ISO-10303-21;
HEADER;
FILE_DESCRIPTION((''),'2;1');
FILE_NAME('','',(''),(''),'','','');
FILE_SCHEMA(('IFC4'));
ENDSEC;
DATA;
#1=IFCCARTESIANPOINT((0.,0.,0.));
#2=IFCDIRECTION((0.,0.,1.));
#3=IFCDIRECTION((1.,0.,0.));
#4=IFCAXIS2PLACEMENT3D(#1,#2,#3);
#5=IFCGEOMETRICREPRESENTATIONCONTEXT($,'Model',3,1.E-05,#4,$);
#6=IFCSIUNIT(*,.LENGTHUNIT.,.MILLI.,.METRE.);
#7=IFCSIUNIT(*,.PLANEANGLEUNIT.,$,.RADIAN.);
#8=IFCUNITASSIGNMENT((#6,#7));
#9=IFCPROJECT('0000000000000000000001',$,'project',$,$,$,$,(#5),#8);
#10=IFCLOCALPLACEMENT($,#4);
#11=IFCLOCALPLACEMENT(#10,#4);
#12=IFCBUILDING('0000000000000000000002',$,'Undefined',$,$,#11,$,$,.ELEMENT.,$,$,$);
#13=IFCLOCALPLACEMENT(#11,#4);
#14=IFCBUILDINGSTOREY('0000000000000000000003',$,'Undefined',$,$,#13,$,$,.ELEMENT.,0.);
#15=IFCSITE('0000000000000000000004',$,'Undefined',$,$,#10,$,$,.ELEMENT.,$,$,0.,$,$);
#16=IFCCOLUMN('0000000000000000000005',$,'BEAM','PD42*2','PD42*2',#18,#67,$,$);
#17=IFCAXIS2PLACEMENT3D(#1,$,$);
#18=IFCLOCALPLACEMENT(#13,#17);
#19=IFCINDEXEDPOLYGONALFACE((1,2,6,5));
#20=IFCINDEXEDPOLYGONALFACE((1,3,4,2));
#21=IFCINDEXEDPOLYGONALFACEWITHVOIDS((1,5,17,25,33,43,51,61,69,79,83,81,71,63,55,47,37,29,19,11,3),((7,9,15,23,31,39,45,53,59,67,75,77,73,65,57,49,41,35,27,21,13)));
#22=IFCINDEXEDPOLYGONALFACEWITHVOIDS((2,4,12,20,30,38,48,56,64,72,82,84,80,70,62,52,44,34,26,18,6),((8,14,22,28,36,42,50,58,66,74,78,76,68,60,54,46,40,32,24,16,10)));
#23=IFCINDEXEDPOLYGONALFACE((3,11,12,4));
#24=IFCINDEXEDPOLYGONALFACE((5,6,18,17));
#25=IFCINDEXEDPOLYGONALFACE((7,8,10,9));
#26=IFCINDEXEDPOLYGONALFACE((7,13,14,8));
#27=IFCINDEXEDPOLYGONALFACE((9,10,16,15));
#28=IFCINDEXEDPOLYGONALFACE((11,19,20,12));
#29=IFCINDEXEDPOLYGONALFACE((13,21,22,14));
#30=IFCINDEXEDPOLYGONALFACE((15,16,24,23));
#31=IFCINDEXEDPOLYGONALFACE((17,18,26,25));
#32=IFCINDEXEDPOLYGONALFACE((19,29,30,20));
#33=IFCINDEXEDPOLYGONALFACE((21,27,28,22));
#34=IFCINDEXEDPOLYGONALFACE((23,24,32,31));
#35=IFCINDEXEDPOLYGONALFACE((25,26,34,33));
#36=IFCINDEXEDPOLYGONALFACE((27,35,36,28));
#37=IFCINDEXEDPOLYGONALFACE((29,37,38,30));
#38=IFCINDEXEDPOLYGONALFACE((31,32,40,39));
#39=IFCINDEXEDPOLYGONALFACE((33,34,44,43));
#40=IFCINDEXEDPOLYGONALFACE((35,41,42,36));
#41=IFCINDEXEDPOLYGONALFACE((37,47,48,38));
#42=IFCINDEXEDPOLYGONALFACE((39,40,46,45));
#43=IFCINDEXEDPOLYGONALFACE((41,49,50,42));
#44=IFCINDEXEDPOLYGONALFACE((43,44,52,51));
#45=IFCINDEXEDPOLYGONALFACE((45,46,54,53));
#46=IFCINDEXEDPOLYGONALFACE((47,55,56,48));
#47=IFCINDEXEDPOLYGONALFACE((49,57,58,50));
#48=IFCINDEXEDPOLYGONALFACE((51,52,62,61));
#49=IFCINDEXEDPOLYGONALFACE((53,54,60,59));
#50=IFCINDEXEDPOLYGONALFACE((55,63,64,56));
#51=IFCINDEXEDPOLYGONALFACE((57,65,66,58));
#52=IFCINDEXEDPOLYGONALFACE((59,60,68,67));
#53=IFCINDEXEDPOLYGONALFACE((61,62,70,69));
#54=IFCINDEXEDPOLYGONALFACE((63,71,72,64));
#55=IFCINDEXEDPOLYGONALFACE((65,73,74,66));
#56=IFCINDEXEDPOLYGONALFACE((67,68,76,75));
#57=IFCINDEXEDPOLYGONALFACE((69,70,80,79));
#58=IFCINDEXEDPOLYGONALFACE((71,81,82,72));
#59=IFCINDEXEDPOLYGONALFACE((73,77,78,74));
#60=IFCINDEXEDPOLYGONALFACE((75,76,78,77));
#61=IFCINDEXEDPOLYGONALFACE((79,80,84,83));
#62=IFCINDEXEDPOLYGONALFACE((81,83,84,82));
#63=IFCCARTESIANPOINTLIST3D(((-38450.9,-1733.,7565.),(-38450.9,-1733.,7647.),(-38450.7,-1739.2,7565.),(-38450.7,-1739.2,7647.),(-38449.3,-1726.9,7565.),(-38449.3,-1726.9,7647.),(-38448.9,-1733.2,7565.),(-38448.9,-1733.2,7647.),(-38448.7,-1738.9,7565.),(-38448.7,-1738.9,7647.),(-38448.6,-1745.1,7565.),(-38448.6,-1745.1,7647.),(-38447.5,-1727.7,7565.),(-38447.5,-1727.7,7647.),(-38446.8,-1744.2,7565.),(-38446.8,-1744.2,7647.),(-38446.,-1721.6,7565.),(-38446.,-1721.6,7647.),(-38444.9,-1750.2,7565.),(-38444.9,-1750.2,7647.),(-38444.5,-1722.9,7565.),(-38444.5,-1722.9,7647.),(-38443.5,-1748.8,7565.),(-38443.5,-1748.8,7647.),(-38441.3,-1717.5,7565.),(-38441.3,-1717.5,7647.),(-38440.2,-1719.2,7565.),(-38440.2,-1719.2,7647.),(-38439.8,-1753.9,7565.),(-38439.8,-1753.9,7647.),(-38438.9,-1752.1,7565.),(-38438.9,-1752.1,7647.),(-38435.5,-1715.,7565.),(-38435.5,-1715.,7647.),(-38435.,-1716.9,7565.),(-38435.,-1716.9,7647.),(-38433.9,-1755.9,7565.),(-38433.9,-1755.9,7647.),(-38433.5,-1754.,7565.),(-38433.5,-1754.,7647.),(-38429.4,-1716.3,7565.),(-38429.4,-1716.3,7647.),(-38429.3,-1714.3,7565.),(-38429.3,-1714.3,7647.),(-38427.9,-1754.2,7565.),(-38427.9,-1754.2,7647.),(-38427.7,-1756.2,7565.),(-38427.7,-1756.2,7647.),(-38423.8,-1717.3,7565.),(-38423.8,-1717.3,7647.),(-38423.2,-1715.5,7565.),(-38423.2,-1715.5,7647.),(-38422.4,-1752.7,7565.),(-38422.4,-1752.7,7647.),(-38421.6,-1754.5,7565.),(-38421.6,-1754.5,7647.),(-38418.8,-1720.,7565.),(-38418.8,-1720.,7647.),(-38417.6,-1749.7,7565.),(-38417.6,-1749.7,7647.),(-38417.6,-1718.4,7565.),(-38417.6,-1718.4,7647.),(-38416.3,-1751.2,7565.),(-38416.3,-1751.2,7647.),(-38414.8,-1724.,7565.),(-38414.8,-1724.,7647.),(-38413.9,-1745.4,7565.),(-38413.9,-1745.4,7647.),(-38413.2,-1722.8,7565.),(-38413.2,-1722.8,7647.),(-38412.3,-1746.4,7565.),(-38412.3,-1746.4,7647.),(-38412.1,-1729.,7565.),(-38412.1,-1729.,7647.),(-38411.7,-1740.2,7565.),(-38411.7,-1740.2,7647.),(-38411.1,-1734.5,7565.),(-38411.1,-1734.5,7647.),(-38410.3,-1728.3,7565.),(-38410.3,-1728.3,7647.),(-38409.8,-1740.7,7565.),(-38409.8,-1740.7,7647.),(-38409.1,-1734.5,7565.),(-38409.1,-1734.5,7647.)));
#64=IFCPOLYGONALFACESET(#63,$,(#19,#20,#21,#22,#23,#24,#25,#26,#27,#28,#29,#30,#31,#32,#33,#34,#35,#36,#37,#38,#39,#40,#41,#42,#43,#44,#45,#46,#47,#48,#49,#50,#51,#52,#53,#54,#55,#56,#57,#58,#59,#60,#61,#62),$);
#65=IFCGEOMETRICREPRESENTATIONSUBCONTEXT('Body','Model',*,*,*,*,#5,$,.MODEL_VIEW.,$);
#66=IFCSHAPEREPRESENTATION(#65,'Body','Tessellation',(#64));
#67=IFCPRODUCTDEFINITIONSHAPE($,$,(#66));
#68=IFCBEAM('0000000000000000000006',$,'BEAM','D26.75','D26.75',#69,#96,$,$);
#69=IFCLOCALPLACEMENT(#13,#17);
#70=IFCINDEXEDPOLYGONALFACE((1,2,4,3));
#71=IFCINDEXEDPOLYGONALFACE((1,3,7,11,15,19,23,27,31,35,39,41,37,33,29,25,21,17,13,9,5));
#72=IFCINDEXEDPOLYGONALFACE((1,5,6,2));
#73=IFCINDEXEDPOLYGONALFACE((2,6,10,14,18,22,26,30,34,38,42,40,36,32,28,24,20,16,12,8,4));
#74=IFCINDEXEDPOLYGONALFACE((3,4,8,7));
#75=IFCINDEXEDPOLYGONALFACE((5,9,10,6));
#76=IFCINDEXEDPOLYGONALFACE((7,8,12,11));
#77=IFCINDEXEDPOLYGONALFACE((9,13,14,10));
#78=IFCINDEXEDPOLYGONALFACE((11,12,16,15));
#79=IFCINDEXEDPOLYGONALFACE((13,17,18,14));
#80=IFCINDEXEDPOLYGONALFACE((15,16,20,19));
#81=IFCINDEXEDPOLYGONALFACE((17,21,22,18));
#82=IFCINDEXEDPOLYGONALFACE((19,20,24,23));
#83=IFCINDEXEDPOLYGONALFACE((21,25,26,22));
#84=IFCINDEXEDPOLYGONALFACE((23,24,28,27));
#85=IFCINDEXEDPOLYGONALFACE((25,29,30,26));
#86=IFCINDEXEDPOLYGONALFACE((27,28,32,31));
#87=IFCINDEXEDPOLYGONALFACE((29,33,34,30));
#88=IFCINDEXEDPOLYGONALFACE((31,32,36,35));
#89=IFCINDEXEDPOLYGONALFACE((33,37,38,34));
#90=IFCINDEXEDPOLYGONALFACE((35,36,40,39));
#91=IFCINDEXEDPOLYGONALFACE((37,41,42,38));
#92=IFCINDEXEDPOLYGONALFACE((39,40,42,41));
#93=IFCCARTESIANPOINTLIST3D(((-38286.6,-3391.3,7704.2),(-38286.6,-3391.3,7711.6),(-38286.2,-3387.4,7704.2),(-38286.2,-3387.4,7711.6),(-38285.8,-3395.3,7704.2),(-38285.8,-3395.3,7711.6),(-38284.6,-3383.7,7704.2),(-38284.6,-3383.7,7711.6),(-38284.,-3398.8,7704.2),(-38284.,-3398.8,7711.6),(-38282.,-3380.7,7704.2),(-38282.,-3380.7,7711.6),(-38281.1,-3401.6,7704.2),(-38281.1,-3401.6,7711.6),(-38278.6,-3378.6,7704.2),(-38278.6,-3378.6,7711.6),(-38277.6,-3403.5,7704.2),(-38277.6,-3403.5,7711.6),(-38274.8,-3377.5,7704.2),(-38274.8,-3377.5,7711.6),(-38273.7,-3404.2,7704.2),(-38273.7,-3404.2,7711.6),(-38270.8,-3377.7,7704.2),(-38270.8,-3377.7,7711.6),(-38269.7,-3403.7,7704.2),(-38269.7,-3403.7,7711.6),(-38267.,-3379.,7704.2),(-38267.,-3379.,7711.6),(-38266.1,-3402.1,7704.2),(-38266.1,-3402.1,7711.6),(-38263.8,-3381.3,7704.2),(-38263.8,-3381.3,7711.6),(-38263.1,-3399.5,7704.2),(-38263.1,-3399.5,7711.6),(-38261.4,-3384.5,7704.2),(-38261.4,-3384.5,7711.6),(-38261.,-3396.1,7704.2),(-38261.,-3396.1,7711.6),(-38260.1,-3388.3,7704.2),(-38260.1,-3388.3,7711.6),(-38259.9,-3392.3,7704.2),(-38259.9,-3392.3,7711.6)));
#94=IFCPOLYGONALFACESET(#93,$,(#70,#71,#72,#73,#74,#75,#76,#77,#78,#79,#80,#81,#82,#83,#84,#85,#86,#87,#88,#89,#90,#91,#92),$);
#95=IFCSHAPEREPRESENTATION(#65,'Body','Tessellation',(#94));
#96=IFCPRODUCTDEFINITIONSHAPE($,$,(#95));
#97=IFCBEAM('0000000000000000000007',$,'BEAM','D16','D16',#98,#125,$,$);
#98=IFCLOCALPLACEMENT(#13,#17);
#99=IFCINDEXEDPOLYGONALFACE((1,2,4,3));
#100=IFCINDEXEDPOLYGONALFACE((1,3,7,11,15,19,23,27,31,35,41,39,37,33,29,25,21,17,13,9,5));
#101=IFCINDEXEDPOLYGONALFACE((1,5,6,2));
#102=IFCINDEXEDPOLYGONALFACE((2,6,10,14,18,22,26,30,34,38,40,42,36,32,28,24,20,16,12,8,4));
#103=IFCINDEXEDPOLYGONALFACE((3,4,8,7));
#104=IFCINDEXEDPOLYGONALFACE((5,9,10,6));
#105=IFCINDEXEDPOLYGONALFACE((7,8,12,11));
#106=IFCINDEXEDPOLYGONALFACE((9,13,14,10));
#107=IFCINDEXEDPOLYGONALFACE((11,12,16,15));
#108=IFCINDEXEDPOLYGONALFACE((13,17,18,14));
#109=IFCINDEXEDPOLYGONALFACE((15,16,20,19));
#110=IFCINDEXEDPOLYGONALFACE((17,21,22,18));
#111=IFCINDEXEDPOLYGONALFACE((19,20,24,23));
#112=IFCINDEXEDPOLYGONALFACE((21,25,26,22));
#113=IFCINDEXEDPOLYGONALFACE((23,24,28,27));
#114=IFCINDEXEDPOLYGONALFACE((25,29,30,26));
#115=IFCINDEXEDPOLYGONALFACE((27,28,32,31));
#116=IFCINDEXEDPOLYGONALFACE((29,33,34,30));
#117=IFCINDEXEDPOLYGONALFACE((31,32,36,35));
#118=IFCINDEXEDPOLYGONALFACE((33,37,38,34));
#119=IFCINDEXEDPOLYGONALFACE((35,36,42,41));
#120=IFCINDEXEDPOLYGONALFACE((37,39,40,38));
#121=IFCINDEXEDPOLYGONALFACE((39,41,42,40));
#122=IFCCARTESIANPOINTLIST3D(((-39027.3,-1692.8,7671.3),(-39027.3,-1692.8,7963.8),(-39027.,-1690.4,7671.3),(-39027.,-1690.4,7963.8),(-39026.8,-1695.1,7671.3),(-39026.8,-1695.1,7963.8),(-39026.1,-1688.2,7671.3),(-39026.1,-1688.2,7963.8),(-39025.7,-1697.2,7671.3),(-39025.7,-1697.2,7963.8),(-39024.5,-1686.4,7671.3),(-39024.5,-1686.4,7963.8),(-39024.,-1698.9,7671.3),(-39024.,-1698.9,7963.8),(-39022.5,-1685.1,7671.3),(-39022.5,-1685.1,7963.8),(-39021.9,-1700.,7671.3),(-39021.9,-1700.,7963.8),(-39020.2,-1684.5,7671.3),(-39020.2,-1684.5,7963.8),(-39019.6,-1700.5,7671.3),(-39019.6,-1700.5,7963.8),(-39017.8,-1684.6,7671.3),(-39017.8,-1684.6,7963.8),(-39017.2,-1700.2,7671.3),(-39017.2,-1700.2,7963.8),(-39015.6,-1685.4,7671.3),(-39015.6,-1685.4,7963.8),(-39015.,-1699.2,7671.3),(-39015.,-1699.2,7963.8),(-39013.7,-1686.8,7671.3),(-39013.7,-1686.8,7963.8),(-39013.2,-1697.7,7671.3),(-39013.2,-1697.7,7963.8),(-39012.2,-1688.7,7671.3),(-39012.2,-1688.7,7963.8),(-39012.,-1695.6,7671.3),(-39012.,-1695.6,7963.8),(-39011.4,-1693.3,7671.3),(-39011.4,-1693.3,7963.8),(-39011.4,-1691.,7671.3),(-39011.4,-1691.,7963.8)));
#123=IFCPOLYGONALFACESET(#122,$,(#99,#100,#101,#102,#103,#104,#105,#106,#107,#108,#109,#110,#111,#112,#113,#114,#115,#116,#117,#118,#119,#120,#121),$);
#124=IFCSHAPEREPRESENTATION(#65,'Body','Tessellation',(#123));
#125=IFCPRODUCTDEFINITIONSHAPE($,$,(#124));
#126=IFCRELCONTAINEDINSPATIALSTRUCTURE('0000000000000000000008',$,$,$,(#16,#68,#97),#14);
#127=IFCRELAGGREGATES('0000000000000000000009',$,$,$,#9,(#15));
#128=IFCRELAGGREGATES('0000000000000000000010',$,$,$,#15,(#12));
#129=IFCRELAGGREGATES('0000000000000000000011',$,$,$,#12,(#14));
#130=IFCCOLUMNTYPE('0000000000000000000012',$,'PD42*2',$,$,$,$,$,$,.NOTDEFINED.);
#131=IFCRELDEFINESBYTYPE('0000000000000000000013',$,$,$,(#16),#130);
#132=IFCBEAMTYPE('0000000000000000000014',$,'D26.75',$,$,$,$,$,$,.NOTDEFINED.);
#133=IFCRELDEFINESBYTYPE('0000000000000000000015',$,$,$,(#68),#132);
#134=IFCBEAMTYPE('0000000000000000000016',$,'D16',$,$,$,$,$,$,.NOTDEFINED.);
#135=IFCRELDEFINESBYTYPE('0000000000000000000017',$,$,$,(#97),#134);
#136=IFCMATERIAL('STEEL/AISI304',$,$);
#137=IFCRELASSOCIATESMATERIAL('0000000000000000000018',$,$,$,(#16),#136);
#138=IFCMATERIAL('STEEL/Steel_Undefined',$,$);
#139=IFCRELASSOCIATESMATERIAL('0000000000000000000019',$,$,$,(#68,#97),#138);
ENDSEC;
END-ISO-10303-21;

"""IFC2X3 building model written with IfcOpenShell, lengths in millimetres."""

from ifc_helpers import new_model, si_unit, frame, origin_with_axes, origin_2d_with_axis, place, context, subcontext, project, spatial, circle, hollow_circle, extrude, material, type_object, element, save


model = new_model("IFC2X3")

# Units and contexts
model_context = context("Model", 3, precision=1e-05, world=origin_with_axes())
body_context = subcontext(model_context, "Body", "Model", "MODEL_VIEW")
ifc_project = project(units=[si_unit("LENGTHUNIT", "METRE", prefix="MILLI"), si_unit("PLANEANGLEUNIT", "RADIAN")], contexts=[model_context])

# Site, building, storey
site_placement = place(None, origin_with_axes())
site = spatial("IfcSite", under=ifc_project, at=site_placement, Name="Undefined", CompositionType="ELEMENT", RefElevation=0.0)
building_placement = place(site_placement, origin_with_axes())
building = spatial("IfcBuilding", under=site, at=building_placement, Name="Undefined", CompositionType="ELEMENT")
storey_placement = place(building_placement, origin_with_axes())
storey = spatial("IfcBuildingStorey", under=building, at=storey_placement, Name="Undefined", CompositionType="ELEMENT", Elevation=0.0)

# Column
ifc_material_1 = material(Name="STEEL/AISI304")
column_type = type_object("IfcColumnType", Name="PD42*2", PredefinedType="NOTDEFINED")
column_placement = place(storey_placement, frame((-38430.1, -1735.3, 7565.0), z_axis=(0.0, 0.0, 1.0), x_axis=(1.0, 0.0, 0.0)))
element("IfcColumn", 1, at=column_placement, inside=storey, type_object=column_type, material=ifc_material_1, Name="BEAM", Description="PD42*2", ObjectType="PD42*2", context=body_context, shape_type="SweptSolid", body=[
    extrude(hollow_circle(Radius=21.0, WallThickness=2.0, at=origin_2d_with_axis()), frame((0.0, 0.0, 82.0), z_axis=(0.0, 0.0, -1.0), x_axis=(0.402197, -0.915553, 0.0)), (0.0, 0.0, 1.0), 82.0),
])

# Shared definitions
ifc_material_2 = material(Name="STEEL/Steel_Undefined")
beam_type_1 = type_object("IfcBeamType", Name="D26.75", PredefinedType="NOTDEFINED")

# Beam
beam_1_placement = place(storey_placement, frame((-38273.2, -3390.8, 7711.6), z_axis=(-0.915553, -0.402197, 0.0), x_axis=(0.0, 0.0, -1.0)))
element("IfcBeam", 2, at=beam_1_placement, inside=storey, type_object=beam_type_1, material=ifc_material_2, Name="BEAM", Description="D26.75", ObjectType="D26.75", context=body_context, shape_type="SweptSolid", body=[
    extrude(circle(Radius=13.4, at=origin_2d_with_axis()), frame((7.4, 0.0, 0.0), z_axis=(-1.0, 0.0, 0.0), x_axis=(0.0, -1.0, 0.0)), (0.0, 0.0, 1.0), 7.4),
])

# Beam
beam_type_2 = type_object("IfcBeamType", Name="D16", PredefinedType="NOTDEFINED")
beam_2_placement = place(storey_placement, frame((-39019.3, -1692.5, 7963.8), z_axis=(-0.915553, -0.402198, 0.0), x_axis=(0.0, 0.0, -1.0)))
element("IfcBeam", 3, at=beam_2_placement, inside=storey, type_object=beam_type_2, material=ifc_material_2, Name="BEAM", Description="D16", ObjectType="D16", context=body_context, shape_type="SweptSolid", body=[
    extrude(circle(Radius=8.0, at=origin_2d_with_axis()), frame((292.6, 0.0, 0.0), z_axis=(-1.0, 0.0, 0.0), x_axis=(0.0, -1.0, 0.0)), (0.0, 0.0, 1.0), 292.6),
])

save(model, "model.ifc")
